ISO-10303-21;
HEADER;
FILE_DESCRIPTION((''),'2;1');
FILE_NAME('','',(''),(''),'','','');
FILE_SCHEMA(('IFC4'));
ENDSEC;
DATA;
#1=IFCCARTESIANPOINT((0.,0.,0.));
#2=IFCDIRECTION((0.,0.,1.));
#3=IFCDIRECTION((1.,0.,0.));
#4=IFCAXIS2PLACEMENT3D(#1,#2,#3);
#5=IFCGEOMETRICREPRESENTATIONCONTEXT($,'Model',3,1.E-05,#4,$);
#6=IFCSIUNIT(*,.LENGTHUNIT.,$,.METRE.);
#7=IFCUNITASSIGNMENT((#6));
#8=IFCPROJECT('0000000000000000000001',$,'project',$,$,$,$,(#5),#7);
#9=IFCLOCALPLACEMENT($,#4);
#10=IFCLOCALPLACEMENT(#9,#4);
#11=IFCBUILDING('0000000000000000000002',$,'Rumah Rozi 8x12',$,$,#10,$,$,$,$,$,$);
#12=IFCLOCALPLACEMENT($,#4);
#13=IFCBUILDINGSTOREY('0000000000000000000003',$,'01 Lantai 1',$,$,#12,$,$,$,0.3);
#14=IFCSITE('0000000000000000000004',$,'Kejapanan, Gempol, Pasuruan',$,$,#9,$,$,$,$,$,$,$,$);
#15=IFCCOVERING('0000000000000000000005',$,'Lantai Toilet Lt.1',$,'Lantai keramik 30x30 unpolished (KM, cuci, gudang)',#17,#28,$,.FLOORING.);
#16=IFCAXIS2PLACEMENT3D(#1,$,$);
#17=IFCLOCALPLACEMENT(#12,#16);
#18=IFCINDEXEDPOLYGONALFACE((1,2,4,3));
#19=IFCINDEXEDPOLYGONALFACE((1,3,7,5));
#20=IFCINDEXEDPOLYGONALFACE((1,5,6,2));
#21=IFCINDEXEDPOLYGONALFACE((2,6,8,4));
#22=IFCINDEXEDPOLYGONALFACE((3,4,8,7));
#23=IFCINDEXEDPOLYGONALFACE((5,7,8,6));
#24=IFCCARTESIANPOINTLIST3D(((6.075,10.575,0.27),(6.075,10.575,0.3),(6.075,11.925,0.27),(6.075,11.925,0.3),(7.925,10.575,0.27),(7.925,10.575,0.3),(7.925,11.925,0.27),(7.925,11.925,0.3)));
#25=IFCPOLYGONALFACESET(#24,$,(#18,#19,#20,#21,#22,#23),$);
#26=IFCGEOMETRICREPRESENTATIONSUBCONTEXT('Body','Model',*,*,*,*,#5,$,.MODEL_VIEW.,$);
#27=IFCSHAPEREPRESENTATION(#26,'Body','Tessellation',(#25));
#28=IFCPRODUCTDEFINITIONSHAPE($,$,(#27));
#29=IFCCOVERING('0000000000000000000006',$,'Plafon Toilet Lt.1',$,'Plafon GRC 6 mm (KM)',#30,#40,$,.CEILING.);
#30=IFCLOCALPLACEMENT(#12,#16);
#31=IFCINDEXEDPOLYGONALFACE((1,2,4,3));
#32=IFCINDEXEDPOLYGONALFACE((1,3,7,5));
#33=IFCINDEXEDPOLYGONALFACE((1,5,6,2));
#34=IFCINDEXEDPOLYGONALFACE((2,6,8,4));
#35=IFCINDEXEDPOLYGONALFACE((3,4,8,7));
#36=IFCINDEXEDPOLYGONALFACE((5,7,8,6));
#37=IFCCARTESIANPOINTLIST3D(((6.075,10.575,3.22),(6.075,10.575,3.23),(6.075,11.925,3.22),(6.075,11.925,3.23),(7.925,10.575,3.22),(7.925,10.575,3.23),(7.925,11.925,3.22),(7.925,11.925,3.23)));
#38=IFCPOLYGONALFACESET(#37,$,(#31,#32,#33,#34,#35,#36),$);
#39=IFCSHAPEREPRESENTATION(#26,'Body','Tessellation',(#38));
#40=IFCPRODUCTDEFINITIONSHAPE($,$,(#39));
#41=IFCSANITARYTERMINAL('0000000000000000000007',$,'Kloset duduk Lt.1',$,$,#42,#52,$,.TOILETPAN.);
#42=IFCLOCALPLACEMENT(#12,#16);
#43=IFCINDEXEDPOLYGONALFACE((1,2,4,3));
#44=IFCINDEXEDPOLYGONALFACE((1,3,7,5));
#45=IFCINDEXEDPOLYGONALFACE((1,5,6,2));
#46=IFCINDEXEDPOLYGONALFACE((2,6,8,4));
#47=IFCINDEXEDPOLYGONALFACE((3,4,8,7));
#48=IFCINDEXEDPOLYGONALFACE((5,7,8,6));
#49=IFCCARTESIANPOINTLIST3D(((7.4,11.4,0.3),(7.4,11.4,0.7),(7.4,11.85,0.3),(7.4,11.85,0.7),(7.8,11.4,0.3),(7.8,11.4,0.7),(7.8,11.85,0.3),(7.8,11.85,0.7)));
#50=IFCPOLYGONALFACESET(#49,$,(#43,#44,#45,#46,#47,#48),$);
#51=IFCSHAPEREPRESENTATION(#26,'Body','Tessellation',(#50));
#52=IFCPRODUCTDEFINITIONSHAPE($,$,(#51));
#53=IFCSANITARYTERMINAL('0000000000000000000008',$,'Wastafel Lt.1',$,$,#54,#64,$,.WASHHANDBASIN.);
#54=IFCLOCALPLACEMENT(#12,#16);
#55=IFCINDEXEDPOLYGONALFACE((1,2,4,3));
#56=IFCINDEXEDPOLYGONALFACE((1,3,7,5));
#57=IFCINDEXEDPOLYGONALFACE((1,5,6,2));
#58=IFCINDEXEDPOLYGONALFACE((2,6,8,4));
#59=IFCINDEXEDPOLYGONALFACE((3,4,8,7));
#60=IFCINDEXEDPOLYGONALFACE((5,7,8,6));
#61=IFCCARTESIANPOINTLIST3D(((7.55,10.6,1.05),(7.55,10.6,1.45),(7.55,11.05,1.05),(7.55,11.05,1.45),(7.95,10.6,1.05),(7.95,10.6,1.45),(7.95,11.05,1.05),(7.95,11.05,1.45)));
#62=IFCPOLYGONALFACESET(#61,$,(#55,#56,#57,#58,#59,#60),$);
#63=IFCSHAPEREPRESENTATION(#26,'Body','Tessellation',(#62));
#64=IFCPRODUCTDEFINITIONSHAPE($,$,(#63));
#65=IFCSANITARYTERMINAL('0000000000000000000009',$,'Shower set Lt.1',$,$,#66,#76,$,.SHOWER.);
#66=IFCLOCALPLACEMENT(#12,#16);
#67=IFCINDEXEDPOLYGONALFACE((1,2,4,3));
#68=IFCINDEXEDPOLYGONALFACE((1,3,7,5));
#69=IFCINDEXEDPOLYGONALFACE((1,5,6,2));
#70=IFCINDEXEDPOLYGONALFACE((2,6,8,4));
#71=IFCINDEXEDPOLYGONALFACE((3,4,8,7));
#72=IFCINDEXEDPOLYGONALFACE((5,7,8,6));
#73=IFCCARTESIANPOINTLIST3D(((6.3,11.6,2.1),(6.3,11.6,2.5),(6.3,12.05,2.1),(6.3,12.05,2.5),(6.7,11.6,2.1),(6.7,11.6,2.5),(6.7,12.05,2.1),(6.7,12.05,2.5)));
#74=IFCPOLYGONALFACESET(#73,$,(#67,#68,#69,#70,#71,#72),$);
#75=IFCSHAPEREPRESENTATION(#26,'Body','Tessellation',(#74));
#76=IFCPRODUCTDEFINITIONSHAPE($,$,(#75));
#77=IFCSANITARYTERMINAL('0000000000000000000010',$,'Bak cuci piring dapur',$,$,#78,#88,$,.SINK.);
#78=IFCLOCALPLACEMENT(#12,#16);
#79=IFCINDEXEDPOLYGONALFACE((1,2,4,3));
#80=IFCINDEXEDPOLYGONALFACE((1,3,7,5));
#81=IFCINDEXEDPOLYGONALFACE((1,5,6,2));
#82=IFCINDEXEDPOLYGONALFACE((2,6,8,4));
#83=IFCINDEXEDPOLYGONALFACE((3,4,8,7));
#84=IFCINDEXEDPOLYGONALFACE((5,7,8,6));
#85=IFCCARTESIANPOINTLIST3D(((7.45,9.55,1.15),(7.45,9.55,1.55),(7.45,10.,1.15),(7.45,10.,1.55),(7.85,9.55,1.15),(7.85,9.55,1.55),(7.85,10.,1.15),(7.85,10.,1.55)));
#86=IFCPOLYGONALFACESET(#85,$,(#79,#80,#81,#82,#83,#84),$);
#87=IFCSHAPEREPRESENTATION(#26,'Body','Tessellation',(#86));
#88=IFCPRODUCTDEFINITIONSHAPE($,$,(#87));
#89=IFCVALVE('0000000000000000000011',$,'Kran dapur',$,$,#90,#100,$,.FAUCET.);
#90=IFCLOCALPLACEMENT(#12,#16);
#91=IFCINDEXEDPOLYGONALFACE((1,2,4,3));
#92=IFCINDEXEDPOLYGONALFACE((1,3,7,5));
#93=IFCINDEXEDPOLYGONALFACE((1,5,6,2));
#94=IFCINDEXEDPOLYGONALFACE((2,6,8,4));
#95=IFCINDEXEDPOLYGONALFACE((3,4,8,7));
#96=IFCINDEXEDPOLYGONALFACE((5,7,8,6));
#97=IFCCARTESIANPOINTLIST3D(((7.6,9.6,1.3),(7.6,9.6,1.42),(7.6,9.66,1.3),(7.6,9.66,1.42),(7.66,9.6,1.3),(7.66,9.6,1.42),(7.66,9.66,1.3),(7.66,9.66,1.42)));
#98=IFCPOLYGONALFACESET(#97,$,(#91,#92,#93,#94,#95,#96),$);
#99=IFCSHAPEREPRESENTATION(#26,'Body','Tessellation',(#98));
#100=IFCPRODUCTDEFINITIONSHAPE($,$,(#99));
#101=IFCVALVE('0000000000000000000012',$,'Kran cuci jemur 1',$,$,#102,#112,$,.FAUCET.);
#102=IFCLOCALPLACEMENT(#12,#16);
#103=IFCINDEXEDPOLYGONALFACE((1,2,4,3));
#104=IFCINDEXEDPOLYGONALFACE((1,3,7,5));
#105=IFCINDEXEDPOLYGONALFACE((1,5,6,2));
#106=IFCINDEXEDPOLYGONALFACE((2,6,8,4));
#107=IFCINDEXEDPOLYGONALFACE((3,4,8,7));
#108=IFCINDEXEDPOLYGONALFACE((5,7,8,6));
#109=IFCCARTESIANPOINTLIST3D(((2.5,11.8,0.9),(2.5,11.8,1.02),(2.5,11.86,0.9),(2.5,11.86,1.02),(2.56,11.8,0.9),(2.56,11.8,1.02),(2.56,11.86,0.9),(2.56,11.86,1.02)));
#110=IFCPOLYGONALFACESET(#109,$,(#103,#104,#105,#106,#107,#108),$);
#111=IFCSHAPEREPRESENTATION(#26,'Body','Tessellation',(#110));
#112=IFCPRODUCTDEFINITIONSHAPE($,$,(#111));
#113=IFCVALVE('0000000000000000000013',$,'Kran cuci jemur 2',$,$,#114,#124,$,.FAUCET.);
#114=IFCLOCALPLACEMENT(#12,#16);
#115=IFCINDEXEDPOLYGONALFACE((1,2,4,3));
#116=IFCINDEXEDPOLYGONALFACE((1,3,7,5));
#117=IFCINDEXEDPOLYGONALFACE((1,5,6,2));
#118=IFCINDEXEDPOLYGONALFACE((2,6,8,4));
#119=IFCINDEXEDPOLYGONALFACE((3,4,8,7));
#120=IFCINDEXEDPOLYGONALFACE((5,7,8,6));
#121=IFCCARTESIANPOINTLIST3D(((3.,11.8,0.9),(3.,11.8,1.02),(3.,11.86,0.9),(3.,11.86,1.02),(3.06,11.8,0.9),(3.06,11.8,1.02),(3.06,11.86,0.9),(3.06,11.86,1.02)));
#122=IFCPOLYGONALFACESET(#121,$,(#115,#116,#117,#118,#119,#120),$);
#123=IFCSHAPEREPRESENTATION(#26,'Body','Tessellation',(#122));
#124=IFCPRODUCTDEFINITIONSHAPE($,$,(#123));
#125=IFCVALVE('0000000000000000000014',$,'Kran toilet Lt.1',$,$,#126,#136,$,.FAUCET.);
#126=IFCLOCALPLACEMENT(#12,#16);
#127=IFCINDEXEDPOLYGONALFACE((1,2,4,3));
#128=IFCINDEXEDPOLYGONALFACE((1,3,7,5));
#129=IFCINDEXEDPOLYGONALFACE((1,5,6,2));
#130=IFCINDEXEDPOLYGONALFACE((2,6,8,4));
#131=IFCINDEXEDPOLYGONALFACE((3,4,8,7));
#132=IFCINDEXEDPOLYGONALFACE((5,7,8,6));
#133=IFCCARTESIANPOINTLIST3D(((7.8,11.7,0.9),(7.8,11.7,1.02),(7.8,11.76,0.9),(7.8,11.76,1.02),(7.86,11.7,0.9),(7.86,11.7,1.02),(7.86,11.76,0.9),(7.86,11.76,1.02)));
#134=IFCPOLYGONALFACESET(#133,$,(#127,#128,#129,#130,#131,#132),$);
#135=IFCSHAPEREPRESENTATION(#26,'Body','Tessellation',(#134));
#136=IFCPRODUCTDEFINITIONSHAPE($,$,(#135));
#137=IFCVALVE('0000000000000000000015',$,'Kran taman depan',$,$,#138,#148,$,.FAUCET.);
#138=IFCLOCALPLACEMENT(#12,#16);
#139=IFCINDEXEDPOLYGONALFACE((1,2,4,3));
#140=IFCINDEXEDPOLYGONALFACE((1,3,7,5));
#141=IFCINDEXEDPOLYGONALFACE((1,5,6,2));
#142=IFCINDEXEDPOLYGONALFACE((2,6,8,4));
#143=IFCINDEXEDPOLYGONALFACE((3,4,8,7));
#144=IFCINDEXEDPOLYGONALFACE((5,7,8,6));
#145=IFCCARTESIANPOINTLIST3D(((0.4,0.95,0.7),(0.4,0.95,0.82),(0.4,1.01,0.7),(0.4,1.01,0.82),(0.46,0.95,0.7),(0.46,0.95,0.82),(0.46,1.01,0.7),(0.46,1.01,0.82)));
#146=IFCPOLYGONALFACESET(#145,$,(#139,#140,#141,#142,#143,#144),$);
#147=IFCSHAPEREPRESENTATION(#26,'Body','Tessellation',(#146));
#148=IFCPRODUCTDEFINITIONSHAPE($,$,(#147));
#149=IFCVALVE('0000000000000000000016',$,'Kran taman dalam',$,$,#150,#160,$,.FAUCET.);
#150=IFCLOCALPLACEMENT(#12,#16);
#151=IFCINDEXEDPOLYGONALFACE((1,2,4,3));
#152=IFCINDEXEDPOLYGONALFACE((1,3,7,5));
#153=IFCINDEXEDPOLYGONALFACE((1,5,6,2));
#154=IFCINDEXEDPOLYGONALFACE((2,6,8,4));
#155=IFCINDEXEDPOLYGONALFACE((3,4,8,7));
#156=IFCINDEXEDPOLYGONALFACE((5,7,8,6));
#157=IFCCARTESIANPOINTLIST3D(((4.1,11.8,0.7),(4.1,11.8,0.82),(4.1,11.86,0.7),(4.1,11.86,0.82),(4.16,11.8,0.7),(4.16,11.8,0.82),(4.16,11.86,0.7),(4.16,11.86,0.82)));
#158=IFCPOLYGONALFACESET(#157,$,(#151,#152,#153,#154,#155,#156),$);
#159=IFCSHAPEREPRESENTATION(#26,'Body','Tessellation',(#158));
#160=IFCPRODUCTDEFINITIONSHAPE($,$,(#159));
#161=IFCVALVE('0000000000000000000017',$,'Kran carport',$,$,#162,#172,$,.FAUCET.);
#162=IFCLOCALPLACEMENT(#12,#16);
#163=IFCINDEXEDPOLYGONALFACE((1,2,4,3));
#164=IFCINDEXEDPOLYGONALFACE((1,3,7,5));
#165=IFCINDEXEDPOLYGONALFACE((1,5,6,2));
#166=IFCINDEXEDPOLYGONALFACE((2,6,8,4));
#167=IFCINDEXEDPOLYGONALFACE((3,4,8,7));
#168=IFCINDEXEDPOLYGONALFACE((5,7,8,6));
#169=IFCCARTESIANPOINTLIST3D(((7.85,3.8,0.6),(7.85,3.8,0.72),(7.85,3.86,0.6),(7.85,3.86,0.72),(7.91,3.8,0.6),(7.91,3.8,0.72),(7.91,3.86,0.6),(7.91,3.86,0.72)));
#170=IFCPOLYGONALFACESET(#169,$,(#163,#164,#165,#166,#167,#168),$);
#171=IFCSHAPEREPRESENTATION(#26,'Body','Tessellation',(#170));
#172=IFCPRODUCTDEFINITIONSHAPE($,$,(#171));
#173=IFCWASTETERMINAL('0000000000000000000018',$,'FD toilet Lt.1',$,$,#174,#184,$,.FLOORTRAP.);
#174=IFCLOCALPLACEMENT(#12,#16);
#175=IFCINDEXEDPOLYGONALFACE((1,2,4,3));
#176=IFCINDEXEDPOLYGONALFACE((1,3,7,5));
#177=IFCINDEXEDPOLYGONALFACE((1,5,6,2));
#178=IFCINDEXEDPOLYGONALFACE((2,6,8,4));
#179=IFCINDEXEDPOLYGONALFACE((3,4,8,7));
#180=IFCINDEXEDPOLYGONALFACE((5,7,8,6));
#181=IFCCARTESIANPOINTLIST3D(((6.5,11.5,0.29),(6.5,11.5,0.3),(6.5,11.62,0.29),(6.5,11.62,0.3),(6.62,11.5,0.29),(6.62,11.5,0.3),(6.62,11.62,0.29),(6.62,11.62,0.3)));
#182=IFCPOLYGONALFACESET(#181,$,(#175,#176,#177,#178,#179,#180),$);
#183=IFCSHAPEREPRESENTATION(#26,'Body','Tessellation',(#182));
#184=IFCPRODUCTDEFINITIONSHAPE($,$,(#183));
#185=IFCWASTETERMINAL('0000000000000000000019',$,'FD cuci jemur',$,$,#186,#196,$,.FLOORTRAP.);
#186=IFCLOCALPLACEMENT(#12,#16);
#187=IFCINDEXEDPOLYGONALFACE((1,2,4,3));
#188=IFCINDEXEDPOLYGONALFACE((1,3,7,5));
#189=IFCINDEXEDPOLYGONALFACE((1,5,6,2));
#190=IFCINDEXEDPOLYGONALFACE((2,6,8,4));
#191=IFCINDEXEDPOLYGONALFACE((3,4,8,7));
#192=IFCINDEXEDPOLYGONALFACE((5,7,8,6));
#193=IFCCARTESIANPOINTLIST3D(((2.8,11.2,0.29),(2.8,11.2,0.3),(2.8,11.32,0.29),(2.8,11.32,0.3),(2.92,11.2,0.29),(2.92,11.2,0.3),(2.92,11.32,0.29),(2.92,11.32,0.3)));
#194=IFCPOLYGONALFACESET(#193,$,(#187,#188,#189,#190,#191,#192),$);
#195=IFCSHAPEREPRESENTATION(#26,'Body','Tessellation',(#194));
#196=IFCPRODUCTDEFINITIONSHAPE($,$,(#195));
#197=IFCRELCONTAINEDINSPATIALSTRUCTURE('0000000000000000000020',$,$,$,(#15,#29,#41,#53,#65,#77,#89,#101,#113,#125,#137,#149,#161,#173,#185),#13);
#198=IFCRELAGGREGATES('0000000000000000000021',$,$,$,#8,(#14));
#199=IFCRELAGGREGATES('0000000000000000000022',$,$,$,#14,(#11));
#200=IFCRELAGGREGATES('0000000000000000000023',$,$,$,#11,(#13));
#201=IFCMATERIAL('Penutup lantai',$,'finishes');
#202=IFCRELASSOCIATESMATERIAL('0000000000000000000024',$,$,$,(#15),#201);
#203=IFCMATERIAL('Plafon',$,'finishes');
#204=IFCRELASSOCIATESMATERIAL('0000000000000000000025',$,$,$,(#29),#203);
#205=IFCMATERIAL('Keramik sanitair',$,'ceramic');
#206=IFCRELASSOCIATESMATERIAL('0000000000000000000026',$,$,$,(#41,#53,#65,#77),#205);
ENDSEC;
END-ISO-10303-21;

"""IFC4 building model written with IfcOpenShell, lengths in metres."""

from ifc_helpers import new_model, si_unit, frame, origin_with_axes, place, context, subcontext, project, spatial, line, indexed_curve, outline, extrude, material, element, save


model = new_model("IFC4")

# Units and contexts
model_context = context("Model", 3, precision=1e-05, world=origin_with_axes())
body_context = subcontext(model_context, "Body", "Model", "MODEL_VIEW")
ifc_project = project(units=[si_unit("LENGTHUNIT", "METRE")], contexts=[model_context])

# Site, building, storey
site_placement = place(None, origin_with_axes())
site = spatial("IfcSite", under=ifc_project, at=site_placement, Name="Kejapanan, Gempol, Pasuruan")
building_placement = place(site_placement, origin_with_axes())
building = spatial("IfcBuilding", under=site, at=building_placement, Name="Rumah Rozi 8x12")
storey_placement = place(None, origin_with_axes())
storey = spatial("IfcBuildingStorey", under=building, at=storey_placement, Name="01 Lantai 1", Elevation=0.3)

# Coverings
ifc_material_1 = material(Name="Penutup lantai", Category="finishes")
covering_1_placement = place(storey_placement, origin_with_axes())
element("IfcCovering", 1, at=covering_1_placement, inside=storey, material=ifc_material_1, Name="Lantai Toilet Lt.1", ObjectType="Lantai keramik 30x30 unpolished (KM, cuci, gudang)", PredefinedType="FLOORING", context=body_context, shape_type="SweptSolid", body=[
    extrude(outline(indexed_curve([(6.075, 10.575), (7.925, 10.575), (7.925, 11.925), (6.075, 11.925)], segments=[line(1, 2, 3, 4, 1)])), frame((0.0, 0.0, 0.27), z_axis=(0.0, 0.0, 1.0), x_axis=(1.0, 0.0, 0.0)), (0.0, 0.0, 1.0), 0.03),
])
ifc_material_2 = material(Name="Plafon", Category="finishes")
covering_2_placement = place(storey_placement, origin_with_axes())
element("IfcCovering", 2, at=covering_2_placement, inside=storey, material=ifc_material_2, Name="Plafon Toilet Lt.1", ObjectType="Plafon GRC 6 mm (KM)", PredefinedType="CEILING", context=body_context, shape_type="SweptSolid", body=[
    extrude(outline(indexed_curve([(6.075, 10.575), (7.925, 10.575), (7.925, 11.925), (6.075, 11.925)], segments=[line(1, 2, 3, 4, 1)])), frame((0.0, 0.0, 3.22), z_axis=(0.0, 0.0, 1.0), x_axis=(1.0, 0.0, 0.0)), (0.0, 0.0, 1.0), 0.01),
])

# Sanitary terminals
ifc_material_3 = material(Name="Keramik sanitair", Category="ceramic")
sanitary_terminal_1_placement = place(storey_placement, origin_with_axes())
element("IfcSanitaryTerminal", 3, at=sanitary_terminal_1_placement, inside=storey, material=ifc_material_3, Name="Kloset duduk Lt.1", PredefinedType="TOILETPAN", context=body_context, shape_type="SweptSolid", body=[
    extrude(outline(indexed_curve([(7.4, 11.4), (7.8, 11.4), (7.8, 11.85), (7.4, 11.85)], segments=[line(1, 2, 3, 4, 1)])), frame((0.0, 0.0, 0.3), z_axis=(0.0, 0.0, 1.0), x_axis=(1.0, 0.0, 0.0)), (0.0, 0.0, 1.0), 0.4),
])
sanitary_terminal_2_placement = place(storey_placement, origin_with_axes())
element("IfcSanitaryTerminal", 4, at=sanitary_terminal_2_placement, inside=storey, material=ifc_material_3, Name="Wastafel Lt.1", PredefinedType="WASHHANDBASIN", context=body_context, shape_type="SweptSolid", body=[
    extrude(outline(indexed_curve([(7.55, 10.6), (7.95, 10.6), (7.95, 11.05), (7.55, 11.05)], segments=[line(1, 2, 3, 4, 1)])), frame((0.0, 0.0, 1.05), z_axis=(0.0, 0.0, 1.0), x_axis=(1.0, 0.0, 0.0)), (0.0, 0.0, 1.0), 0.4),
])
sanitary_terminal_3_placement = place(storey_placement, origin_with_axes())
element("IfcSanitaryTerminal", 5, at=sanitary_terminal_3_placement, inside=storey, material=ifc_material_3, Name="Shower set Lt.1", PredefinedType="SHOWER", context=body_context, shape_type="SweptSolid", body=[
    extrude(outline(indexed_curve([(6.3, 11.6), (6.7, 11.6), (6.7, 12.05), (6.3, 12.05)], segments=[line(1, 2, 3, 4, 1)])), frame((0.0, 0.0, 2.1), z_axis=(0.0, 0.0, 1.0), x_axis=(1.0, 0.0, 0.0)), (0.0, 0.0, 1.0), 0.4),
])
sanitary_terminal_4_placement = place(storey_placement, origin_with_axes())
element("IfcSanitaryTerminal", 6, at=sanitary_terminal_4_placement, inside=storey, material=ifc_material_3, Name="Bak cuci piring dapur", PredefinedType="SINK", context=body_context, shape_type="SweptSolid", body=[
    extrude(outline(indexed_curve([(7.45, 9.55), (7.85, 9.55), (7.85, 10.0), (7.45, 10.0)], segments=[line(1, 2, 3, 4, 1)])), frame((0.0, 0.0, 1.15), z_axis=(0.0, 0.0, 1.0), x_axis=(1.0, 0.0, 0.0)), (0.0, 0.0, 1.0), 0.4),
])

# Valves
valve_1_placement = place(storey_placement, origin_with_axes())
element("IfcValve", 7, at=valve_1_placement, inside=storey, Name="Kran dapur", PredefinedType="FAUCET", context=body_context, shape_type="SweptSolid", body=[
    extrude(outline(indexed_curve([(7.6, 9.6), (7.66, 9.6), (7.66, 9.66), (7.6, 9.66)], segments=[line(1, 2, 3, 4, 1)])), frame((0.0, 0.0, 1.3), z_axis=(0.0, 0.0, 1.0), x_axis=(1.0, 0.0, 0.0)), (0.0, 0.0, 1.0), 0.12),
])
valve_2_placement = place(storey_placement, origin_with_axes())
element("IfcValve", 8, at=valve_2_placement, inside=storey, Name="Kran cuci jemur 1", PredefinedType="FAUCET", context=body_context, shape_type="SweptSolid", body=[
    extrude(outline(indexed_curve([(2.5, 11.8), (2.56, 11.8), (2.56, 11.86), (2.5, 11.86)], segments=[line(1, 2, 3, 4, 1)])), frame((0.0, 0.0, 0.9), z_axis=(0.0, 0.0, 1.0), x_axis=(1.0, 0.0, 0.0)), (0.0, 0.0, 1.0), 0.12),
])
valve_3_placement = place(storey_placement, origin_with_axes())
element("IfcValve", 9, at=valve_3_placement, inside=storey, Name="Kran cuci jemur 2", PredefinedType="FAUCET", context=body_context, shape_type="SweptSolid", body=[
    extrude(outline(indexed_curve([(3.0, 11.8), (3.06, 11.8), (3.06, 11.86), (3.0, 11.86)], segments=[line(1, 2, 3, 4, 1)])), frame((0.0, 0.0, 0.9), z_axis=(0.0, 0.0, 1.0), x_axis=(1.0, 0.0, 0.0)), (0.0, 0.0, 1.0), 0.12),
])
valve_4_placement = place(storey_placement, origin_with_axes())
element("IfcValve", 10, at=valve_4_placement, inside=storey, Name="Kran toilet Lt.1", PredefinedType="FAUCET", context=body_context, shape_type="SweptSolid", body=[
    extrude(outline(indexed_curve([(7.8, 11.7), (7.86, 11.7), (7.86, 11.76), (7.8, 11.76)], segments=[line(1, 2, 3, 4, 1)])), frame((0.0, 0.0, 0.9), z_axis=(0.0, 0.0, 1.0), x_axis=(1.0, 0.0, 0.0)), (0.0, 0.0, 1.0), 0.12),
])
valve_5_placement = place(storey_placement, origin_with_axes())
element("IfcValve", 11, at=valve_5_placement, inside=storey, Name="Kran taman depan", PredefinedType="FAUCET", context=body_context, shape_type="SweptSolid", body=[
    extrude(outline(indexed_curve([(0.4, 0.95), (0.46, 0.95), (0.46, 1.01), (0.4, 1.01)], segments=[line(1, 2, 3, 4, 1)])), frame((0.0, 0.0, 0.7), z_axis=(0.0, 0.0, 1.0), x_axis=(1.0, 0.0, 0.0)), (0.0, 0.0, 1.0), 0.12),
])
valve_6_placement = place(storey_placement, origin_with_axes())
element("IfcValve", 12, at=valve_6_placement, inside=storey, Name="Kran taman dalam", PredefinedType="FAUCET", context=body_context, shape_type="SweptSolid", body=[
    extrude(outline(indexed_curve([(4.1, 11.8), (4.16, 11.8), (4.16, 11.86), (4.1, 11.86)], segments=[line(1, 2, 3, 4, 1)])), frame((0.0, 0.0, 0.7), z_axis=(0.0, 0.0, 1.0), x_axis=(1.0, 0.0, 0.0)), (0.0, 0.0, 1.0), 0.12),
])
valve_7_placement = place(storey_placement, origin_with_axes())
element("IfcValve", 13, at=valve_7_placement, inside=storey, Name="Kran carport", PredefinedType="FAUCET", context=body_context, shape_type="SweptSolid", body=[
    extrude(outline(indexed_curve([(7.85, 3.8), (7.91, 3.8), (7.91, 3.86), (7.85, 3.86)], segments=[line(1, 2, 3, 4, 1)])), frame((0.0, 0.0, 0.6), z_axis=(0.0, 0.0, 1.0), x_axis=(1.0, 0.0, 0.0)), (0.0, 0.0, 1.0), 0.12),
])

# Waste terminals
waste_terminal_1_placement = place(storey_placement, origin_with_axes())
element("IfcWasteTerminal", 14, at=waste_terminal_1_placement, inside=storey, Name="FD toilet Lt.1", PredefinedType="FLOORTRAP", context=body_context, shape_type="SweptSolid", body=[
    extrude(outline(indexed_curve([(6.5, 11.5), (6.62, 11.5), (6.62, 11.62), (6.5, 11.62)], segments=[line(1, 2, 3, 4, 1)])), frame((0.0, 0.0, 0.29), z_axis=(0.0, 0.0, 1.0), x_axis=(1.0, 0.0, 0.0)), (0.0, 0.0, 1.0), 0.01),
])
waste_terminal_2_placement = place(storey_placement, origin_with_axes())
element("IfcWasteTerminal", 15, at=waste_terminal_2_placement, inside=storey, Name="FD cuci jemur", PredefinedType="FLOORTRAP", context=body_context, shape_type="SweptSolid", body=[
    extrude(outline(indexed_curve([(2.8, 11.2), (2.92, 11.2), (2.92, 11.32), (2.8, 11.32)], segments=[line(1, 2, 3, 4, 1)])), frame((0.0, 0.0, 0.29), z_axis=(0.0, 0.0, 1.0), x_axis=(1.0, 0.0, 0.0)), (0.0, 0.0, 1.0), 0.01),
])

save(model, "model.ifc")
